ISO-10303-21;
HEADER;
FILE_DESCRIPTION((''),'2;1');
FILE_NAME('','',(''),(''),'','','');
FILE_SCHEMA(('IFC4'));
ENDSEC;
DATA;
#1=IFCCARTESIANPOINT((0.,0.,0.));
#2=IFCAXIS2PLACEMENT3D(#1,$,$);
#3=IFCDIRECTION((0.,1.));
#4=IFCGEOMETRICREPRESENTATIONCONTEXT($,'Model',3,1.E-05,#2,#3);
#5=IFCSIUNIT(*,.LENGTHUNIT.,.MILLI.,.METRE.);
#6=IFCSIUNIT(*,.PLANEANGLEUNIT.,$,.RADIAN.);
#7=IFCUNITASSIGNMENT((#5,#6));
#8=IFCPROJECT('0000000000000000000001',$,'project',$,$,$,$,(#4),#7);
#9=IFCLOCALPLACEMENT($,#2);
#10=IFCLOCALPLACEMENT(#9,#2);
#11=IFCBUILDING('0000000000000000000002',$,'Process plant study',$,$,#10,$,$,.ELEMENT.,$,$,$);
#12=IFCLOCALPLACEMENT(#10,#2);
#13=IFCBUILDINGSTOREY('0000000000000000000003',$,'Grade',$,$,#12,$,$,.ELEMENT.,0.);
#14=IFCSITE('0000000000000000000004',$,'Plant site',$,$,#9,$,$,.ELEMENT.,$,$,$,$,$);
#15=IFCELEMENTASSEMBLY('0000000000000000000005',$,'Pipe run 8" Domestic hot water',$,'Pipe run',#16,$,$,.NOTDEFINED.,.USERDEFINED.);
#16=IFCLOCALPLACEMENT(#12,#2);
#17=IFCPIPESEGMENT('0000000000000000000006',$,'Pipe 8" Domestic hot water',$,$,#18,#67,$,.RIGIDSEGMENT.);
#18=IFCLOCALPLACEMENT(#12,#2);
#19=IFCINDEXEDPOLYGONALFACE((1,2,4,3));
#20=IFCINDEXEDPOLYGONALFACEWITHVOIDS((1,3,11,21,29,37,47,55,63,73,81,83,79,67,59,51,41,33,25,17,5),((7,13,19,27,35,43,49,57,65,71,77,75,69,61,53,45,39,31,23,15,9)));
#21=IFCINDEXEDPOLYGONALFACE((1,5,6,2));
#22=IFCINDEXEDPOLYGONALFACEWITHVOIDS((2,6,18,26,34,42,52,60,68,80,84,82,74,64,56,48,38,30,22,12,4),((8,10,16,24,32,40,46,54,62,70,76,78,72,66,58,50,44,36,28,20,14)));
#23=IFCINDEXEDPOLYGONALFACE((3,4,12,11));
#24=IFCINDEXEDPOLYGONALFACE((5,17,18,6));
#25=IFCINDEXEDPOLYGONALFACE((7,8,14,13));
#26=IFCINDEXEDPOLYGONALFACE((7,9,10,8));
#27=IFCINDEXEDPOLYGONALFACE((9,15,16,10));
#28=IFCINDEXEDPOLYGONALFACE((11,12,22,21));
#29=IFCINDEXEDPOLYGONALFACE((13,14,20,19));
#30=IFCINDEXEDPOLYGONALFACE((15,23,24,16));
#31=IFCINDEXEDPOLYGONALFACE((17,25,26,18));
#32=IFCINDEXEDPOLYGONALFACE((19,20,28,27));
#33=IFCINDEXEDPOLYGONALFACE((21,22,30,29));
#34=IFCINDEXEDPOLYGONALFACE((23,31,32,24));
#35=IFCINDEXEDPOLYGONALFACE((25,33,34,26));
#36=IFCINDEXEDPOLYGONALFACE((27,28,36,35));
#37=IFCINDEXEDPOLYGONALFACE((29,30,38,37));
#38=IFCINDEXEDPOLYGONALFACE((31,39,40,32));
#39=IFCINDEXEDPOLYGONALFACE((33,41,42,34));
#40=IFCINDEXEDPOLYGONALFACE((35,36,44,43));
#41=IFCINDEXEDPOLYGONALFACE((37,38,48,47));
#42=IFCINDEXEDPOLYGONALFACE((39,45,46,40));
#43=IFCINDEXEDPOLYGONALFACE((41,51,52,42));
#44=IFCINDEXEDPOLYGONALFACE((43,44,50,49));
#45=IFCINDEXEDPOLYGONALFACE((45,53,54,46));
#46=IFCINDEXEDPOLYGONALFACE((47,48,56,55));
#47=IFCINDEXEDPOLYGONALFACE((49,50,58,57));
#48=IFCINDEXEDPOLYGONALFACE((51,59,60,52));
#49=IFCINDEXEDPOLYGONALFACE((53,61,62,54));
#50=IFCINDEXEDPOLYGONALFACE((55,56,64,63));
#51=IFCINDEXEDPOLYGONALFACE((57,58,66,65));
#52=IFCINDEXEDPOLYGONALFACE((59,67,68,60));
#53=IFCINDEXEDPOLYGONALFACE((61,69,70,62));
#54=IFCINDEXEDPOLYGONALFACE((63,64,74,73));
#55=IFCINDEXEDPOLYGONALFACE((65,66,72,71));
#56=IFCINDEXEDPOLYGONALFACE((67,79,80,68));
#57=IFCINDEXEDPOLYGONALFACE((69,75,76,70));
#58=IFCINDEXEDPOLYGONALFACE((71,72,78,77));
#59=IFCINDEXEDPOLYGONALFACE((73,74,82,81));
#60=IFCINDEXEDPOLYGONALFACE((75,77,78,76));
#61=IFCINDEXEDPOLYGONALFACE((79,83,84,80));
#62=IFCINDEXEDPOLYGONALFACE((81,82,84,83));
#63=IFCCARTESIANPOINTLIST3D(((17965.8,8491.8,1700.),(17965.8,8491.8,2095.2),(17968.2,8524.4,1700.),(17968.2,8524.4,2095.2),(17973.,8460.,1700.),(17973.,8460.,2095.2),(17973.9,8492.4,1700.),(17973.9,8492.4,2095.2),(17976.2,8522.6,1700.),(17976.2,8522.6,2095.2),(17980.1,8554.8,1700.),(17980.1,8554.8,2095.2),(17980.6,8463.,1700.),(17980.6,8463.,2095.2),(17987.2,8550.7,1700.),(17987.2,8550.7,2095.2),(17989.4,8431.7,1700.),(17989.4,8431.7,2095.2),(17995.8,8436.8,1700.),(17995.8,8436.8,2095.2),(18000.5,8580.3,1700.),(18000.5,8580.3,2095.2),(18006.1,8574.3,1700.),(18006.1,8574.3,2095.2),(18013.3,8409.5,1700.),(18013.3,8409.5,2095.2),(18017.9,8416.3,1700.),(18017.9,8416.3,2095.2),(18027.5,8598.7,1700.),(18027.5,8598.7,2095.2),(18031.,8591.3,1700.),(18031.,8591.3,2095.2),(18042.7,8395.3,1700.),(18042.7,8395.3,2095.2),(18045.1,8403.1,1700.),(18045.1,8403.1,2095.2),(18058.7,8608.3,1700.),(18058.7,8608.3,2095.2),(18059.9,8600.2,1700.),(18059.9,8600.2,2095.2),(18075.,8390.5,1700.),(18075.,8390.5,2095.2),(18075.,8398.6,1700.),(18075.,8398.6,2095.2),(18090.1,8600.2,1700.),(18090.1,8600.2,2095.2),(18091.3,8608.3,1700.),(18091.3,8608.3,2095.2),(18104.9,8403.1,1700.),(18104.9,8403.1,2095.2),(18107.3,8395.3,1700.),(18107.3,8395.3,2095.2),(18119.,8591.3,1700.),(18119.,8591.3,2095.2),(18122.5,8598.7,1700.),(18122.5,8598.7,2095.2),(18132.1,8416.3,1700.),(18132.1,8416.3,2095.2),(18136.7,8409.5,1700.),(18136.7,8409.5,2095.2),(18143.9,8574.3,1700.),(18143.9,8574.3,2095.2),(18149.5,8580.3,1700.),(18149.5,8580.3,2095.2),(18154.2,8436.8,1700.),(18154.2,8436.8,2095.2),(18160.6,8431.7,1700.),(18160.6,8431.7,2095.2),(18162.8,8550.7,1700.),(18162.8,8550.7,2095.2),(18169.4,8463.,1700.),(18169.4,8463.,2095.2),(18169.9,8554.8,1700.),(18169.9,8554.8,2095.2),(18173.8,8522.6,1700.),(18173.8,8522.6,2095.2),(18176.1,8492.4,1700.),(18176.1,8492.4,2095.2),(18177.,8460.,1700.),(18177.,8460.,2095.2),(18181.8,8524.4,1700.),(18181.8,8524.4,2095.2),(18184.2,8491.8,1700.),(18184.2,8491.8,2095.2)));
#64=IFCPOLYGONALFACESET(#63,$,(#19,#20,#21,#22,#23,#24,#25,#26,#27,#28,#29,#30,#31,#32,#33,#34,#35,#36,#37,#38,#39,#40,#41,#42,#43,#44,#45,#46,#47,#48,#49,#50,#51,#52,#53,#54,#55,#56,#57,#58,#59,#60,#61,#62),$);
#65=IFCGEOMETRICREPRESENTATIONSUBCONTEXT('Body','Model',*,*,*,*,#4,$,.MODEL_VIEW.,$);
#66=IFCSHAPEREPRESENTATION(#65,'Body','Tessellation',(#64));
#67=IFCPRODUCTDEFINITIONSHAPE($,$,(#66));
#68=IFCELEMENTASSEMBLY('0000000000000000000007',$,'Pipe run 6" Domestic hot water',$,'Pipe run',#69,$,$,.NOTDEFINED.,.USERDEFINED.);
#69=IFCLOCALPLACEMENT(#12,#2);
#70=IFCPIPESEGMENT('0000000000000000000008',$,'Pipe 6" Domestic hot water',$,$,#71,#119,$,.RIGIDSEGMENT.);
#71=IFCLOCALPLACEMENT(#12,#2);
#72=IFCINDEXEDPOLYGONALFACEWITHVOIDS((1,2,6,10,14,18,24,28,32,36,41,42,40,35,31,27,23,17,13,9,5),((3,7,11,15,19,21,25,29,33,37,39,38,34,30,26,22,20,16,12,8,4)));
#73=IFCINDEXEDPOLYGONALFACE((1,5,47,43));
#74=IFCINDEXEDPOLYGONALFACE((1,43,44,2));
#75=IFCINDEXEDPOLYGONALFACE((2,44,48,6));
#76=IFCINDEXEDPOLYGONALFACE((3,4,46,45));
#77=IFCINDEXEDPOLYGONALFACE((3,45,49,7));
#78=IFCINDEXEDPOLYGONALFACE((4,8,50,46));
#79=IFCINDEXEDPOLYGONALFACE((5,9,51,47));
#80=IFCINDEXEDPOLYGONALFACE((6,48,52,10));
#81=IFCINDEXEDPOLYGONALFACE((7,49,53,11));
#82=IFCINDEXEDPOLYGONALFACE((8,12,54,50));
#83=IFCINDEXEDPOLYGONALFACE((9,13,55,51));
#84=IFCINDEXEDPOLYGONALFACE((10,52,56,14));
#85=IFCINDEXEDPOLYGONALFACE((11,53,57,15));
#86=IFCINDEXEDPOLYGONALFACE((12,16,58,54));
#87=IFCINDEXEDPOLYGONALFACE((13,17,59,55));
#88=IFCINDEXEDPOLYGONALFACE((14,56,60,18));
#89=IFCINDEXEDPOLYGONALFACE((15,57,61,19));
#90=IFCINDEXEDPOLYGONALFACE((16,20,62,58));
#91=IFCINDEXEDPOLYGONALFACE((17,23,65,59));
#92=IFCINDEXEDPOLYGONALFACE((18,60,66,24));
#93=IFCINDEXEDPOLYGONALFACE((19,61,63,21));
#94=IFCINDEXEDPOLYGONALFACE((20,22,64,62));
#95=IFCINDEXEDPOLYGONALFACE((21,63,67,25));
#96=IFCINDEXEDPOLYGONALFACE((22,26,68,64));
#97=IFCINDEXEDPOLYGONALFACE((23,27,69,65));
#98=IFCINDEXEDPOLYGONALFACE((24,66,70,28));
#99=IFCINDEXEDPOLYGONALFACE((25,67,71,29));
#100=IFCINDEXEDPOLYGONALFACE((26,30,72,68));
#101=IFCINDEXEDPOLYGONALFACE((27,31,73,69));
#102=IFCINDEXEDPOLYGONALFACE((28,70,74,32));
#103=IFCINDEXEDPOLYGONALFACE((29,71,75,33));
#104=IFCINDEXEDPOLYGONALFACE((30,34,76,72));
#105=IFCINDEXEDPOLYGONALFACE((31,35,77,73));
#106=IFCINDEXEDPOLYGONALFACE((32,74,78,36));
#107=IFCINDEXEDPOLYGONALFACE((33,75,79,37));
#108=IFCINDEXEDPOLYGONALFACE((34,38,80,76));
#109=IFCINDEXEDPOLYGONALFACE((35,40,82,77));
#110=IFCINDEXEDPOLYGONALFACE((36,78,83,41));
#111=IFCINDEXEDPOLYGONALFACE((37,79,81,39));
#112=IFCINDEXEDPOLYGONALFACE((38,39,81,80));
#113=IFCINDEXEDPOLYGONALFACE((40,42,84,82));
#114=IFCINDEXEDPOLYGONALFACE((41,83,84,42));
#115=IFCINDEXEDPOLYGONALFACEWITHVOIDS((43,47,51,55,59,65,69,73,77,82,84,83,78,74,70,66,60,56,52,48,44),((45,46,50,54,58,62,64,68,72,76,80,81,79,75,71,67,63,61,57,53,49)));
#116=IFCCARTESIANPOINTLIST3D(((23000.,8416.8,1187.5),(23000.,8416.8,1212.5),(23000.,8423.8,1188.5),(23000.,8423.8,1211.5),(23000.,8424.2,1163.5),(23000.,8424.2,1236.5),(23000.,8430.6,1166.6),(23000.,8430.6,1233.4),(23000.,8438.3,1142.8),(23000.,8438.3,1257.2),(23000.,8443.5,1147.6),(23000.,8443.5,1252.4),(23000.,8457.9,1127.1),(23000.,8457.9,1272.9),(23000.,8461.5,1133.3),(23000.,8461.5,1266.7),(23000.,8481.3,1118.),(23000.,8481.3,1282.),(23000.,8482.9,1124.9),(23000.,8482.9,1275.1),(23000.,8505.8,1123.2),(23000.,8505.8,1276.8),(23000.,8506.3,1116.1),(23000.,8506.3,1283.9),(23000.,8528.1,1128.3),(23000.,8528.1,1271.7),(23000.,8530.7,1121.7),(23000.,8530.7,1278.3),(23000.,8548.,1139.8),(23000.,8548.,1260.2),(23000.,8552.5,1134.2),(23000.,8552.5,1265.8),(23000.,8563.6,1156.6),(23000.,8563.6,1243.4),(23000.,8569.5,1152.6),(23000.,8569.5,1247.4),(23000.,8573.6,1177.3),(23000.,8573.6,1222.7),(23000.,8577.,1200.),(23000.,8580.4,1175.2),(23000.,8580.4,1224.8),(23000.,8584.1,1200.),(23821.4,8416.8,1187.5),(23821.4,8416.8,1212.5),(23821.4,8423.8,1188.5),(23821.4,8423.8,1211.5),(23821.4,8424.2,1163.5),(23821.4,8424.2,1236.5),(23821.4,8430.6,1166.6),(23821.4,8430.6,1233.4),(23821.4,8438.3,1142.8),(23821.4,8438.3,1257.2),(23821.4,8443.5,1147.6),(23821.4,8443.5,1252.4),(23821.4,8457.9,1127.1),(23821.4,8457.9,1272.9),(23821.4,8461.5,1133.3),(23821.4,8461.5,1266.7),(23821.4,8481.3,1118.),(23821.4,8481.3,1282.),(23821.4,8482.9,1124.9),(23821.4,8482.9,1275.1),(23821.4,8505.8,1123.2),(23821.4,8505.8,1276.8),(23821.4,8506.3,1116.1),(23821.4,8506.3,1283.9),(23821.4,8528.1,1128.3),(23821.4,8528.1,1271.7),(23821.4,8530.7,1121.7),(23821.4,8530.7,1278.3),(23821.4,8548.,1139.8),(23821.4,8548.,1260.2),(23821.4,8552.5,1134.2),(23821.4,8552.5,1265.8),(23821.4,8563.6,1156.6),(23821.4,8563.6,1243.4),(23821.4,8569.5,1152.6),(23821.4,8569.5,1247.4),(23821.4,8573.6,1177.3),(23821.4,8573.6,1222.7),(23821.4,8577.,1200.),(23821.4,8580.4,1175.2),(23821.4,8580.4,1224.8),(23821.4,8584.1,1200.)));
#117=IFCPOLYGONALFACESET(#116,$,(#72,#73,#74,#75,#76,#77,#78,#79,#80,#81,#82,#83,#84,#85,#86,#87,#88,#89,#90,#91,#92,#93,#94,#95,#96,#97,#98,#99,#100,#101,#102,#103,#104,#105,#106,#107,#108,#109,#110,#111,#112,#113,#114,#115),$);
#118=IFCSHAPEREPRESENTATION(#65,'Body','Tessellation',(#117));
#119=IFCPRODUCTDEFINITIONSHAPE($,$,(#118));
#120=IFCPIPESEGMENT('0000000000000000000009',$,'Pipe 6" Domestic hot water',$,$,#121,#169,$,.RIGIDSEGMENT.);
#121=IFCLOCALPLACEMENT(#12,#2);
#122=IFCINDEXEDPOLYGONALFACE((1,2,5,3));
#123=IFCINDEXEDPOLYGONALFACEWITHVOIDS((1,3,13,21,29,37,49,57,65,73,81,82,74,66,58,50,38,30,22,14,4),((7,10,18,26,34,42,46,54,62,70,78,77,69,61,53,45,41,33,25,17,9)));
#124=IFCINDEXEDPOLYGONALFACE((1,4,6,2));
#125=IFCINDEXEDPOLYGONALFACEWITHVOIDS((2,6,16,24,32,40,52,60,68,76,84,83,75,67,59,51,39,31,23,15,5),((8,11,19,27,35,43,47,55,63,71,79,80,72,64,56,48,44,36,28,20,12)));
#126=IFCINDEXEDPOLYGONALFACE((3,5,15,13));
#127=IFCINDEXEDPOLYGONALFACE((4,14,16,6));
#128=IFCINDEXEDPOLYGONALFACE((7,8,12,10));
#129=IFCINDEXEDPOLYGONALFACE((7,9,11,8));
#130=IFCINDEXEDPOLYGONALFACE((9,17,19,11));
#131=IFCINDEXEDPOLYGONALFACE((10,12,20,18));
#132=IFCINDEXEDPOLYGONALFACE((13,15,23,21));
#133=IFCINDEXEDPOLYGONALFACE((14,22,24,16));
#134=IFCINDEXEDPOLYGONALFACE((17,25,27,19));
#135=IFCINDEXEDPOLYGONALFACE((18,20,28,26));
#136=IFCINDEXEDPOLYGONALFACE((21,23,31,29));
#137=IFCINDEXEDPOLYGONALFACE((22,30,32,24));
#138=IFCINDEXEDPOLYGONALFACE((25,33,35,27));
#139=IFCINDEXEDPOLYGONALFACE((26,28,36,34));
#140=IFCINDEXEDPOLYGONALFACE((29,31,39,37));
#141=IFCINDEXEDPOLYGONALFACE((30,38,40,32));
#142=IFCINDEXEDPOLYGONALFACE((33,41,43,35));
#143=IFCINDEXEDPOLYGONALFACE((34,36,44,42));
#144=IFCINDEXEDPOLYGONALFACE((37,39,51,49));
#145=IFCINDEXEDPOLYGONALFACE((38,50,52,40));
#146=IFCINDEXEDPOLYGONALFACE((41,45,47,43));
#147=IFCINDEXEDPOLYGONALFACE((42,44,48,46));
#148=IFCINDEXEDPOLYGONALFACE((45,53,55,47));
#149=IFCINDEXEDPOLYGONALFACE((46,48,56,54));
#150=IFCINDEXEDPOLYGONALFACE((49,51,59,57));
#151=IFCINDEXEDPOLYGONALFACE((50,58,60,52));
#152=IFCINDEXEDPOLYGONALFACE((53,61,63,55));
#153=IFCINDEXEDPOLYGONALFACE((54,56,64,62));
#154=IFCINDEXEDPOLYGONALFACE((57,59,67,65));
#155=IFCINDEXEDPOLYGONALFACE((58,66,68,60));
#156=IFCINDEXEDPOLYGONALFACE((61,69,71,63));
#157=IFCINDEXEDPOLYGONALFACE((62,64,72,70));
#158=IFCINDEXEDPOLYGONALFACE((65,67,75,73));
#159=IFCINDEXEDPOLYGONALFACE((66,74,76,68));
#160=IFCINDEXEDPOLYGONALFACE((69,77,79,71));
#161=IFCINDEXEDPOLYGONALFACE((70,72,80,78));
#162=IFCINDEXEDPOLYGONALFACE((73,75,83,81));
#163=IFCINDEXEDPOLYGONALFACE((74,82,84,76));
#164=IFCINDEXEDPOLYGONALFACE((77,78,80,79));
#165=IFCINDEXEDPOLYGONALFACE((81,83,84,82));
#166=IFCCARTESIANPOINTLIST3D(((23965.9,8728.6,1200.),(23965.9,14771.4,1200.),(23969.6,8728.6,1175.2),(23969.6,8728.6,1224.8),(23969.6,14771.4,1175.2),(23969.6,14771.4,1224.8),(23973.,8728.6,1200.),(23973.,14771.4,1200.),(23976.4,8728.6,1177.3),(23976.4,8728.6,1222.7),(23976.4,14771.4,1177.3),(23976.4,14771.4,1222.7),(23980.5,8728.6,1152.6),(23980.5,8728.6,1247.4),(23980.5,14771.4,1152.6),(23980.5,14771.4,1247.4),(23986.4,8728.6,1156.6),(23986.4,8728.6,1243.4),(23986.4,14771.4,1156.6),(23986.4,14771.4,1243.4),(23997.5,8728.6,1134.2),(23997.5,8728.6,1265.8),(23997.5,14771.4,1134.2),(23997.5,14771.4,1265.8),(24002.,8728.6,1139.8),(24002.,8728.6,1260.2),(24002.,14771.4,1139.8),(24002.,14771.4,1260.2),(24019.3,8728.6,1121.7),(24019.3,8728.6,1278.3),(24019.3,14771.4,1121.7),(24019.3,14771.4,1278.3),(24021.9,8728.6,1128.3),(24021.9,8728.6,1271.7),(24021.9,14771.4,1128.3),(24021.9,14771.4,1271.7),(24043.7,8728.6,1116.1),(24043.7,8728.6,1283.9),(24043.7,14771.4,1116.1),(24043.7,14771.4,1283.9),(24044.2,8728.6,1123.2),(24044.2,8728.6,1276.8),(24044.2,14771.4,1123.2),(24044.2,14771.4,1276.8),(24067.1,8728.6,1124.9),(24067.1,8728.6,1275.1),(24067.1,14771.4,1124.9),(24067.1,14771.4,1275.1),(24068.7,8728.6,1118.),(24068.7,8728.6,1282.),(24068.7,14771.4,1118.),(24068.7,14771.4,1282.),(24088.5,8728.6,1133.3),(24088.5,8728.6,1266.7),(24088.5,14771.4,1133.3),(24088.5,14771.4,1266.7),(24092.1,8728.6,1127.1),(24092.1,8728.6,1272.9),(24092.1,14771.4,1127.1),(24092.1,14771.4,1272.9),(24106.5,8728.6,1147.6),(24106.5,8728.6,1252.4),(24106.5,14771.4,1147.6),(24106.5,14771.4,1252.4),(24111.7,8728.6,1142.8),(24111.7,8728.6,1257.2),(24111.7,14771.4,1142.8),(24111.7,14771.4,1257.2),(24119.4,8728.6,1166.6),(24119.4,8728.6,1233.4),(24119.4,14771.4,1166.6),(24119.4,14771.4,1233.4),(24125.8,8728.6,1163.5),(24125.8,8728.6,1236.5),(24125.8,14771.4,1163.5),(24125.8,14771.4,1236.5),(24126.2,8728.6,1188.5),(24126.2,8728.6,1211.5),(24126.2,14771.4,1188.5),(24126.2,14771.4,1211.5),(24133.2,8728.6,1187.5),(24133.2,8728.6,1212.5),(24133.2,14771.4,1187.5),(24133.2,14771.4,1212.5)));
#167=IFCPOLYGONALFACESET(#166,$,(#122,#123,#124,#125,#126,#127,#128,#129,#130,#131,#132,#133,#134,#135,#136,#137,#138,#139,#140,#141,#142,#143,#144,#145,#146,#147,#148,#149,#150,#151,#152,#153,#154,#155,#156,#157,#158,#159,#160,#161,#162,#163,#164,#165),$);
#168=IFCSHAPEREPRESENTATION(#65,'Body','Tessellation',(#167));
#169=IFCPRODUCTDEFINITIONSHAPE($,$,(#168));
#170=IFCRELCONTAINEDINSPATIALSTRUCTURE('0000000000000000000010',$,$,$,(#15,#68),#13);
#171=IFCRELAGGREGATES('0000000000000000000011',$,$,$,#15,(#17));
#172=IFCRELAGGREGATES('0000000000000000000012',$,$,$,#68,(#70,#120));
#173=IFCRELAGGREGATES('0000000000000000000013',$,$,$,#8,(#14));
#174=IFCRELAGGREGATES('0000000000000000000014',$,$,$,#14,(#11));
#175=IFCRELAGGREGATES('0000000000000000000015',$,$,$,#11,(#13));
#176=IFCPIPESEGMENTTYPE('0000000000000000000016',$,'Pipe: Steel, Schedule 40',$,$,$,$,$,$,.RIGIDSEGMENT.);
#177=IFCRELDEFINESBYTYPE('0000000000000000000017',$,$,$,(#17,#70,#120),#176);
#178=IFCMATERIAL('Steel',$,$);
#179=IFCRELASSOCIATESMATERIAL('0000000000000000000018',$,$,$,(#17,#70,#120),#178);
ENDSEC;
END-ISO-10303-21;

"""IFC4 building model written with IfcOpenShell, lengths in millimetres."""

from ifc_helpers import new_model, si_unit, direction, frame, origin, origin_with_axes, origin_2d, place, context, subcontext, project, spatial, hollow_circle, extrude, material, type_object, element, aggregate, save


model = new_model("IFC4")

# Units and contexts
model_context = context("Model", 3, precision=1e-05, world=origin(), true_north=direction((0.0, 1.0)))
body_context = subcontext(model_context, "Body", "Model", "MODEL_VIEW")
ifc_project = project(units=[si_unit("LENGTHUNIT", "METRE", prefix="MILLI"), si_unit("PLANEANGLEUNIT", "RADIAN")], contexts=[model_context])

# Site, building, storey
site_placement = place(None, origin())
site = spatial("IfcSite", under=ifc_project, at=site_placement, Name="Plant site", CompositionType="ELEMENT")
building_placement = place(site_placement, origin())
building = spatial("IfcBuilding", under=site, at=building_placement, Name="Process plant study", CompositionType="ELEMENT")
storey_placement = place(building_placement, origin())
storey = spatial("IfcBuildingStorey", under=building, at=storey_placement, Name="Grade", CompositionType="ELEMENT", Elevation=0.0)

# Element assemblies, pipe segments
assembly_1_placement = place(storey_placement, origin_with_axes())
assembly_1 = element("IfcElementAssembly", 1, at=assembly_1_placement, inside=storey, Name="Pipe run 8\" Domestic hot water", ObjectType="Pipe run", AssemblyPlace="NOTDEFINED", PredefinedType="USERDEFINED")
ifc_material = material(Name="Steel")
pipe_segment_type = type_object("IfcPipeSegmentType", Name="Pipe: Steel, Schedule 40", PredefinedType="RIGIDSEGMENT")
pipe_segment_1_placement = place(storey_placement, origin_with_axes())
pipe_segment_1 = element("IfcPipeSegment", 2, at=pipe_segment_1_placement, type_object=pipe_segment_type, material=ifc_material, Name="Pipe 8\" Domestic hot water", PredefinedType="RIGIDSEGMENT", context=body_context, shape_type="SweptSolid", body=[
    extrude(hollow_circle(Radius=109.5, WallThickness=8.2, at=origin_2d()), frame((18075.0, 8500.0, 2095.2), z_axis=(0.0, 0.0, -1.0), x_axis=(0.0, -1.0, 0.0)), (0.0, 0.0, 1.0), 395.2),
])
assembly_2_placement = place(storey_placement, origin_with_axes())
assembly_2 = element("IfcElementAssembly", 3, at=assembly_2_placement, inside=storey, Name="Pipe run 6\" Domestic hot water", ObjectType="Pipe run", AssemblyPlace="NOTDEFINED", PredefinedType="USERDEFINED")
pipe_segment_2_placement = place(storey_placement, origin_with_axes())
pipe_segment_2 = element("IfcPipeSegment", 4, at=pipe_segment_2_placement, type_object=pipe_segment_type, material=ifc_material, Name="Pipe 6\" Domestic hot water", PredefinedType="RIGIDSEGMENT", context=body_context, shape_type="SweptSolid", body=[
    extrude(hollow_circle(Radius=84.1, WallThickness=7.1, at=origin_2d()), frame((23000.0, 8500.0, 1200.0), z_axis=(1.0, 0.0, 0.0), x_axis=(0.0, 1.0, 0.0)), (0.0, 0.0, 1.0), 821.4),
])
pipe_segment_3_placement = place(storey_placement, origin_with_axes())
pipe_segment_3 = element("IfcPipeSegment", 5, at=pipe_segment_3_placement, type_object=pipe_segment_type, material=ifc_material, Name="Pipe 6\" Domestic hot water", PredefinedType="RIGIDSEGMENT", context=body_context, shape_type="SweptSolid", body=[
    extrude(hollow_circle(Radius=84.1, WallThickness=7.1, at=origin_2d()), frame((24050.0, 8728.6, 1200.0), z_axis=(0.0, 1.0, 0.0), x_axis=(-1.0, 0.0, 0.0)), (0.0, 0.0, 1.0), 6042.8),
])

aggregate(assembly_1, [pipe_segment_1])
aggregate(assembly_2, [pipe_segment_2, pipe_segment_3])

save(model, "model.ifc")
